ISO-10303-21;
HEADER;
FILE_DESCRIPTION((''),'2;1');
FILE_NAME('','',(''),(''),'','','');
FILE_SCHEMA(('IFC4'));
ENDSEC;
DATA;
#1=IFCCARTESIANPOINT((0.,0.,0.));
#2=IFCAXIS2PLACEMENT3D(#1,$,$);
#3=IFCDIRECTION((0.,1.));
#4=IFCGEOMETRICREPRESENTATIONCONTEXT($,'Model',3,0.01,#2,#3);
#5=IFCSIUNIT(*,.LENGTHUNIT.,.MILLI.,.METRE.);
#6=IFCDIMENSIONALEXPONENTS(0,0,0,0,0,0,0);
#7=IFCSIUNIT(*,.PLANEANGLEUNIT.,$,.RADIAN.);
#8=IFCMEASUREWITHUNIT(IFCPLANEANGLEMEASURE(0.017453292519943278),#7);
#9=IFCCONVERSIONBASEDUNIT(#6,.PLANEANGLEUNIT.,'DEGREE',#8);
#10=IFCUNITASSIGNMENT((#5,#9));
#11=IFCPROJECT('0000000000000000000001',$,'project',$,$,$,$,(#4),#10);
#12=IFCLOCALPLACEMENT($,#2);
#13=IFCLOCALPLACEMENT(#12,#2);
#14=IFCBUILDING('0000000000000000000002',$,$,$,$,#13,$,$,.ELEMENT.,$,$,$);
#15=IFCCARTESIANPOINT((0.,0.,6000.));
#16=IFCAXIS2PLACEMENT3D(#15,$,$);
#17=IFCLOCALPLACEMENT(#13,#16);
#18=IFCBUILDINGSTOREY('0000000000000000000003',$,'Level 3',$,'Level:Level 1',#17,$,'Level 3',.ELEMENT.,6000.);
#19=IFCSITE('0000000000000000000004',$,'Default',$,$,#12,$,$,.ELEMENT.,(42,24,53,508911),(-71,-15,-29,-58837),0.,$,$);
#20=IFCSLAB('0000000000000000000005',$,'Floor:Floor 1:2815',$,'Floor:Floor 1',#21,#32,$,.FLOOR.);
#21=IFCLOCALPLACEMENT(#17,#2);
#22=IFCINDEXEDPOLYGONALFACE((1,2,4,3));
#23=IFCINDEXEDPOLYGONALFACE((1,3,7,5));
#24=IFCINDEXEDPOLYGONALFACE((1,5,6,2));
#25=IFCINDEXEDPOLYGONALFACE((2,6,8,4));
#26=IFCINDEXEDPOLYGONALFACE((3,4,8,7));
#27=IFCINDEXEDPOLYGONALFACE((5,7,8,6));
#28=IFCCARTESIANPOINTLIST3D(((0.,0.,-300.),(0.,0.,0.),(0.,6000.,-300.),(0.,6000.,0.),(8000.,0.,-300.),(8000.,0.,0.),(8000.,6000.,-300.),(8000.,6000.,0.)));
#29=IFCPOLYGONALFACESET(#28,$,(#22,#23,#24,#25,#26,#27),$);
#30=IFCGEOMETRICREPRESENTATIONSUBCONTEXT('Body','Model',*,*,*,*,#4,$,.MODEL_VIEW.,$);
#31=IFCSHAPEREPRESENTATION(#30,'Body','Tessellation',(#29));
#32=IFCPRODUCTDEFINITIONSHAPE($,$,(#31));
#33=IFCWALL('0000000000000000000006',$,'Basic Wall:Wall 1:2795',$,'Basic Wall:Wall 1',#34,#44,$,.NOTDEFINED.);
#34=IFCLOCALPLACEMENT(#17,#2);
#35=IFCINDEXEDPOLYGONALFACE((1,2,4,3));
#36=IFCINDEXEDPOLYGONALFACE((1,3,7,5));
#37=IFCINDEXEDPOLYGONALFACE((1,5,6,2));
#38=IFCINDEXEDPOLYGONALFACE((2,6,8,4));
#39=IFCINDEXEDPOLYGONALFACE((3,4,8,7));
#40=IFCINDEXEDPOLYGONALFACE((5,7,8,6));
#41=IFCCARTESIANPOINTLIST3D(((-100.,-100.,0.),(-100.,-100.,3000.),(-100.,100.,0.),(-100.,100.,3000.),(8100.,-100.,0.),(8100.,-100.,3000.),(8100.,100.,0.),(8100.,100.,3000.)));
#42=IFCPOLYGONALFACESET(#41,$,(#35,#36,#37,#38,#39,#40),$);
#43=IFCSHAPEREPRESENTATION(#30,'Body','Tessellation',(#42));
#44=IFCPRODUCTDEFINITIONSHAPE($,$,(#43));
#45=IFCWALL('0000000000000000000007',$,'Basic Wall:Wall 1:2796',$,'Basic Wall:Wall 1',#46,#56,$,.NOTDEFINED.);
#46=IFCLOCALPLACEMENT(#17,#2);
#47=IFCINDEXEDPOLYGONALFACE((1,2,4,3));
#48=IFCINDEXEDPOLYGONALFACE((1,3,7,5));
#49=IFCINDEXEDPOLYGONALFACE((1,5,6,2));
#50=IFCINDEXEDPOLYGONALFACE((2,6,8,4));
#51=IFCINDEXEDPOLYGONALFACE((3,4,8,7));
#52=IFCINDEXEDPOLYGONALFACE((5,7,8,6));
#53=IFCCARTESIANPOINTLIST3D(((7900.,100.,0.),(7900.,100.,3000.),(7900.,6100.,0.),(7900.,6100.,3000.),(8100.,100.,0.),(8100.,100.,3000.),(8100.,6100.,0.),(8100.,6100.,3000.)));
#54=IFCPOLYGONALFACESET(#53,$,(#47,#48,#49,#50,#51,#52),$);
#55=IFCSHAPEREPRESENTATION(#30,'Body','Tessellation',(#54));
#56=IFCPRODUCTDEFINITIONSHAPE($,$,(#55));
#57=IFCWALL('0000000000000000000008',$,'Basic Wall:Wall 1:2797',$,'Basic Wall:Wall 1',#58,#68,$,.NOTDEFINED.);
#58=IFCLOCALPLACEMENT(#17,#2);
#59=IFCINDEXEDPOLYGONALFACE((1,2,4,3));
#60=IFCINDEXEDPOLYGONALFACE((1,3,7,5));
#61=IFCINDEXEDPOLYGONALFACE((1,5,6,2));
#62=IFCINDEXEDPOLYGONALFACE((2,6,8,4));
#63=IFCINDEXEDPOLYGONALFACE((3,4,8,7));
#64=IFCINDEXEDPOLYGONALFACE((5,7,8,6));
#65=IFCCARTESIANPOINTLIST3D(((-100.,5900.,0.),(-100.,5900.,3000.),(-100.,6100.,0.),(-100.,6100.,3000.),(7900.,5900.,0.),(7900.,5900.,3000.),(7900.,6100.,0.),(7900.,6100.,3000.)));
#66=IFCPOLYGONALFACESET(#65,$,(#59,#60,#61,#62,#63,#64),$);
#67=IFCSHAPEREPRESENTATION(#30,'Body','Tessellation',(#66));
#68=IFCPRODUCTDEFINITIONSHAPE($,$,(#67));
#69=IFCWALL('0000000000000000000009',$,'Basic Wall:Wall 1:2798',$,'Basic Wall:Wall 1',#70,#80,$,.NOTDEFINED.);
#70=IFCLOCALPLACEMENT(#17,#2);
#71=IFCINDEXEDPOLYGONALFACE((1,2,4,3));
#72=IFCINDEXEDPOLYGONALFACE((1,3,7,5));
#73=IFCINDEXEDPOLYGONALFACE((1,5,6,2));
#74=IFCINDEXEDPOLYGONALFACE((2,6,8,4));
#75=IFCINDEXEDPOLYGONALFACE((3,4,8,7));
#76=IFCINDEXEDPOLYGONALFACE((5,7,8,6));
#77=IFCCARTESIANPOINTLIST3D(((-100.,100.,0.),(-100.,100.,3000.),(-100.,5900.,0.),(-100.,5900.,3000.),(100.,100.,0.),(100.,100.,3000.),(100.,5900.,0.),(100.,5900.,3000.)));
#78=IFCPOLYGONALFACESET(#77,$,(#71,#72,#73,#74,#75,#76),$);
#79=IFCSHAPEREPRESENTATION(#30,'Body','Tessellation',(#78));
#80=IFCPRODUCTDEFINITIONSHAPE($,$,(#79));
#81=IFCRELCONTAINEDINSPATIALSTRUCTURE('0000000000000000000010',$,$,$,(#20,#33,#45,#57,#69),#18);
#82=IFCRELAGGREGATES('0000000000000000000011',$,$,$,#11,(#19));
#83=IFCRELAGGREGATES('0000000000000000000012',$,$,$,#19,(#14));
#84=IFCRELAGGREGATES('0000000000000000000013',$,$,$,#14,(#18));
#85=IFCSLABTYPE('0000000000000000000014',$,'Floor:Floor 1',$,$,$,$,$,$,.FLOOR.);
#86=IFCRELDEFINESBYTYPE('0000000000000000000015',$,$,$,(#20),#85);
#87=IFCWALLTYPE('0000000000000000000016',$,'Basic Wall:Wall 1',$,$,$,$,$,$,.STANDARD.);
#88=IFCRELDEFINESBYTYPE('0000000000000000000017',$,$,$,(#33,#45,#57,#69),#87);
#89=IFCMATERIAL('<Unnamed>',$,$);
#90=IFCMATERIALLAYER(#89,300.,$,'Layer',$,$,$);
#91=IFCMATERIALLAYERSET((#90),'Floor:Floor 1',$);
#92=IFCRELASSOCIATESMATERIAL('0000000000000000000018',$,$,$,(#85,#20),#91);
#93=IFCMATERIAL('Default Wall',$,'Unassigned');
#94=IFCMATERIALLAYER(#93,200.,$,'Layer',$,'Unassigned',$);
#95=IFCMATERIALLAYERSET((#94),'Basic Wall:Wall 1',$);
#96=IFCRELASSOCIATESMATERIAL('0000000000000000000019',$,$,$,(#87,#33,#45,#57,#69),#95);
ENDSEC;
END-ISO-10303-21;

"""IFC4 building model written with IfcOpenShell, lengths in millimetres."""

from ifc_helpers import new_model, entity, si_unit, converted_unit, direction, frame, frame_2d, origin, origin_2d_with_axis, place, context, subcontext, project, spatial, rectangle, extrude, material, layer, layer_set, layer_usage, type_object, element, save


model = new_model("IFC4")

# Units and contexts
model_context = context("Model", 3, precision=0.01, world=origin(), true_north=direction((0.0, 1.0)))
body_context = subcontext(model_context, "Body", "Model", "MODEL_VIEW")
ifc_project = project(units=[si_unit("LENGTHUNIT", "METRE", prefix="MILLI"), converted_unit("PLANEANGLEUNIT", "DEGREE", entity("IfcPlaneAngleMeasure", 0.017453292519943278), si_unit("PLANEANGLEUNIT", "RADIAN"), dimensions=[0, 0, 0, 0, 0, 0, 0])], contexts=[model_context])

# Site, building, storey
site_placement = place(None, origin())
site = spatial("IfcSite", under=ifc_project, at=site_placement, Name="Default", CompositionType="ELEMENT", RefLatitude=(42, 24, 53, 508911), RefLongitude=(-71, -15, -29, -58837), RefElevation=0.0)
building_placement = place(site_placement, origin())
building = spatial("IfcBuilding", under=site, at=building_placement, CompositionType="ELEMENT")
storey_placement = place(building_placement, frame((0.0, 0.0, 6000.0)))
storey = spatial("IfcBuildingStorey", under=building, at=storey_placement, Name="Level 3", ObjectType="Level:Level 1", LongName="Level 3", CompositionType="ELEMENT", Elevation=6000.0)

# Slab
ifc_material_1 = material(Name="<Unnamed>")
ifc_layer_1 = layer(ifc_material_1, 300.0, Name="Layer")
ifc_layer_set_1 = layer_set([ifc_layer_1], Name="Floor:Floor 1")
ifc_layer_usage_1 = layer_usage(ifc_layer_set_1, "AXIS3", "POSITIVE", 0.0)
slab_type = type_object("IfcSlabType", Name="Floor:Floor 1", PredefinedType="FLOOR", material=ifc_layer_set_1)
slab_placement = place(storey_placement, origin())
element("IfcSlab", 1, at=slab_placement, inside=storey, type_object=slab_type, material=ifc_layer_usage_1, Name="Floor:Floor 1:2815", ObjectType="Floor:Floor 1", PredefinedType="FLOOR", context=body_context, shape_type="SweptSolid", body=[
    extrude(rectangle(XDim=6000.0, YDim=8000.0, at=origin_2d_with_axis()), frame((4000.0, 3000.0, 0.0), z_axis=(0.0, 0.0, -1.0), x_axis=(0.0, 1.0, 0.0)), (0.0, 0.0, 1.0), 300.0),
])

# Walls
ifc_material_2 = material(Name="Default Wall", Category="Unassigned")
ifc_layer_2 = layer(ifc_material_2, 200.0, Name="Layer", Category="Unassigned")
ifc_layer_set_2 = layer_set([ifc_layer_2], Name="Basic Wall:Wall 1")
ifc_layer_usage_2 = layer_usage(ifc_layer_set_2, "AXIS2", "NEGATIVE", 100.0)
wall_type = type_object("IfcWallType", Name="Basic Wall:Wall 1", PredefinedType="STANDARD", material=ifc_layer_set_2)
wall_1_placement = place(storey_placement, frame((-100.0, 0.0, 0.0)))
element("IfcWall", 2, at=wall_1_placement, inside=storey, type_object=wall_type, material=ifc_layer_usage_2, Name="Basic Wall:Wall 1:2795", ObjectType="Basic Wall:Wall 1", PredefinedType="NOTDEFINED", context=body_context, shape_type="SweptSolid", body=[
    extrude(rectangle(XDim=8200.0, YDim=200.0, at=frame_2d((4100.0, 0.0), x_axis=(-1.0, 0.0))), origin(), (0.0, 0.0, 1.0), 3000.0),
])
ifc_layer_usage_3 = layer_usage(ifc_layer_set_2, "AXIS2", "NEGATIVE", 100.0)
wall_2_placement = place(storey_placement, frame((8000.0, 100.0, 0.0), z_axis=(0.0, 0.0, 1.0), x_axis=(0.0, 1.0, 0.0)))
element("IfcWall", 3, at=wall_2_placement, inside=storey, type_object=wall_type, material=ifc_layer_usage_3, Name="Basic Wall:Wall 1:2796", ObjectType="Basic Wall:Wall 1", PredefinedType="NOTDEFINED", context=body_context, shape_type="SweptSolid", body=[
    extrude(rectangle(XDim=6000.0, YDim=200.0, at=frame_2d((3000.0, 0.0), x_axis=(-1.0, 0.0))), origin(), (0.0, 0.0, 1.0), 3000.0),
])
ifc_layer_usage_4 = layer_usage(ifc_layer_set_2, "AXIS2", "NEGATIVE", 100.0)
wall_3_placement = place(storey_placement, frame((7900.0, 6000.0, 0.0), z_axis=(0.0, 0.0, 1.0), x_axis=(-1.0, 0.0, 0.0)))
element("IfcWall", 4, at=wall_3_placement, inside=storey, type_object=wall_type, material=ifc_layer_usage_4, Name="Basic Wall:Wall 1:2797", ObjectType="Basic Wall:Wall 1", PredefinedType="NOTDEFINED", context=body_context, shape_type="SweptSolid", body=[
    extrude(rectangle(XDim=8000.0, YDim=200.0, at=frame_2d((4000.0, 0.0), x_axis=(-1.0, 0.0))), origin(), (0.0, 0.0, 1.0), 3000.0),
])
ifc_layer_usage_5 = layer_usage(ifc_layer_set_2, "AXIS2", "NEGATIVE", 100.0)
wall_4_placement = place(storey_placement, frame((0.0, 5900.0, 0.0), z_axis=(0.0, 0.0, 1.0), x_axis=(0.0, -1.0, 0.0)))
element("IfcWall", 5, at=wall_4_placement, inside=storey, type_object=wall_type, material=ifc_layer_usage_5, Name="Basic Wall:Wall 1:2798", ObjectType="Basic Wall:Wall 1", PredefinedType="NOTDEFINED", context=body_context, shape_type="SweptSolid", body=[
    extrude(rectangle(XDim=5800.0, YDim=200.0, at=frame_2d((2900.0, 0.0), x_axis=(-1.0, 0.0))), origin(), (0.0, 0.0, 1.0), 3000.0),
])

save(model, "model.ifc")
